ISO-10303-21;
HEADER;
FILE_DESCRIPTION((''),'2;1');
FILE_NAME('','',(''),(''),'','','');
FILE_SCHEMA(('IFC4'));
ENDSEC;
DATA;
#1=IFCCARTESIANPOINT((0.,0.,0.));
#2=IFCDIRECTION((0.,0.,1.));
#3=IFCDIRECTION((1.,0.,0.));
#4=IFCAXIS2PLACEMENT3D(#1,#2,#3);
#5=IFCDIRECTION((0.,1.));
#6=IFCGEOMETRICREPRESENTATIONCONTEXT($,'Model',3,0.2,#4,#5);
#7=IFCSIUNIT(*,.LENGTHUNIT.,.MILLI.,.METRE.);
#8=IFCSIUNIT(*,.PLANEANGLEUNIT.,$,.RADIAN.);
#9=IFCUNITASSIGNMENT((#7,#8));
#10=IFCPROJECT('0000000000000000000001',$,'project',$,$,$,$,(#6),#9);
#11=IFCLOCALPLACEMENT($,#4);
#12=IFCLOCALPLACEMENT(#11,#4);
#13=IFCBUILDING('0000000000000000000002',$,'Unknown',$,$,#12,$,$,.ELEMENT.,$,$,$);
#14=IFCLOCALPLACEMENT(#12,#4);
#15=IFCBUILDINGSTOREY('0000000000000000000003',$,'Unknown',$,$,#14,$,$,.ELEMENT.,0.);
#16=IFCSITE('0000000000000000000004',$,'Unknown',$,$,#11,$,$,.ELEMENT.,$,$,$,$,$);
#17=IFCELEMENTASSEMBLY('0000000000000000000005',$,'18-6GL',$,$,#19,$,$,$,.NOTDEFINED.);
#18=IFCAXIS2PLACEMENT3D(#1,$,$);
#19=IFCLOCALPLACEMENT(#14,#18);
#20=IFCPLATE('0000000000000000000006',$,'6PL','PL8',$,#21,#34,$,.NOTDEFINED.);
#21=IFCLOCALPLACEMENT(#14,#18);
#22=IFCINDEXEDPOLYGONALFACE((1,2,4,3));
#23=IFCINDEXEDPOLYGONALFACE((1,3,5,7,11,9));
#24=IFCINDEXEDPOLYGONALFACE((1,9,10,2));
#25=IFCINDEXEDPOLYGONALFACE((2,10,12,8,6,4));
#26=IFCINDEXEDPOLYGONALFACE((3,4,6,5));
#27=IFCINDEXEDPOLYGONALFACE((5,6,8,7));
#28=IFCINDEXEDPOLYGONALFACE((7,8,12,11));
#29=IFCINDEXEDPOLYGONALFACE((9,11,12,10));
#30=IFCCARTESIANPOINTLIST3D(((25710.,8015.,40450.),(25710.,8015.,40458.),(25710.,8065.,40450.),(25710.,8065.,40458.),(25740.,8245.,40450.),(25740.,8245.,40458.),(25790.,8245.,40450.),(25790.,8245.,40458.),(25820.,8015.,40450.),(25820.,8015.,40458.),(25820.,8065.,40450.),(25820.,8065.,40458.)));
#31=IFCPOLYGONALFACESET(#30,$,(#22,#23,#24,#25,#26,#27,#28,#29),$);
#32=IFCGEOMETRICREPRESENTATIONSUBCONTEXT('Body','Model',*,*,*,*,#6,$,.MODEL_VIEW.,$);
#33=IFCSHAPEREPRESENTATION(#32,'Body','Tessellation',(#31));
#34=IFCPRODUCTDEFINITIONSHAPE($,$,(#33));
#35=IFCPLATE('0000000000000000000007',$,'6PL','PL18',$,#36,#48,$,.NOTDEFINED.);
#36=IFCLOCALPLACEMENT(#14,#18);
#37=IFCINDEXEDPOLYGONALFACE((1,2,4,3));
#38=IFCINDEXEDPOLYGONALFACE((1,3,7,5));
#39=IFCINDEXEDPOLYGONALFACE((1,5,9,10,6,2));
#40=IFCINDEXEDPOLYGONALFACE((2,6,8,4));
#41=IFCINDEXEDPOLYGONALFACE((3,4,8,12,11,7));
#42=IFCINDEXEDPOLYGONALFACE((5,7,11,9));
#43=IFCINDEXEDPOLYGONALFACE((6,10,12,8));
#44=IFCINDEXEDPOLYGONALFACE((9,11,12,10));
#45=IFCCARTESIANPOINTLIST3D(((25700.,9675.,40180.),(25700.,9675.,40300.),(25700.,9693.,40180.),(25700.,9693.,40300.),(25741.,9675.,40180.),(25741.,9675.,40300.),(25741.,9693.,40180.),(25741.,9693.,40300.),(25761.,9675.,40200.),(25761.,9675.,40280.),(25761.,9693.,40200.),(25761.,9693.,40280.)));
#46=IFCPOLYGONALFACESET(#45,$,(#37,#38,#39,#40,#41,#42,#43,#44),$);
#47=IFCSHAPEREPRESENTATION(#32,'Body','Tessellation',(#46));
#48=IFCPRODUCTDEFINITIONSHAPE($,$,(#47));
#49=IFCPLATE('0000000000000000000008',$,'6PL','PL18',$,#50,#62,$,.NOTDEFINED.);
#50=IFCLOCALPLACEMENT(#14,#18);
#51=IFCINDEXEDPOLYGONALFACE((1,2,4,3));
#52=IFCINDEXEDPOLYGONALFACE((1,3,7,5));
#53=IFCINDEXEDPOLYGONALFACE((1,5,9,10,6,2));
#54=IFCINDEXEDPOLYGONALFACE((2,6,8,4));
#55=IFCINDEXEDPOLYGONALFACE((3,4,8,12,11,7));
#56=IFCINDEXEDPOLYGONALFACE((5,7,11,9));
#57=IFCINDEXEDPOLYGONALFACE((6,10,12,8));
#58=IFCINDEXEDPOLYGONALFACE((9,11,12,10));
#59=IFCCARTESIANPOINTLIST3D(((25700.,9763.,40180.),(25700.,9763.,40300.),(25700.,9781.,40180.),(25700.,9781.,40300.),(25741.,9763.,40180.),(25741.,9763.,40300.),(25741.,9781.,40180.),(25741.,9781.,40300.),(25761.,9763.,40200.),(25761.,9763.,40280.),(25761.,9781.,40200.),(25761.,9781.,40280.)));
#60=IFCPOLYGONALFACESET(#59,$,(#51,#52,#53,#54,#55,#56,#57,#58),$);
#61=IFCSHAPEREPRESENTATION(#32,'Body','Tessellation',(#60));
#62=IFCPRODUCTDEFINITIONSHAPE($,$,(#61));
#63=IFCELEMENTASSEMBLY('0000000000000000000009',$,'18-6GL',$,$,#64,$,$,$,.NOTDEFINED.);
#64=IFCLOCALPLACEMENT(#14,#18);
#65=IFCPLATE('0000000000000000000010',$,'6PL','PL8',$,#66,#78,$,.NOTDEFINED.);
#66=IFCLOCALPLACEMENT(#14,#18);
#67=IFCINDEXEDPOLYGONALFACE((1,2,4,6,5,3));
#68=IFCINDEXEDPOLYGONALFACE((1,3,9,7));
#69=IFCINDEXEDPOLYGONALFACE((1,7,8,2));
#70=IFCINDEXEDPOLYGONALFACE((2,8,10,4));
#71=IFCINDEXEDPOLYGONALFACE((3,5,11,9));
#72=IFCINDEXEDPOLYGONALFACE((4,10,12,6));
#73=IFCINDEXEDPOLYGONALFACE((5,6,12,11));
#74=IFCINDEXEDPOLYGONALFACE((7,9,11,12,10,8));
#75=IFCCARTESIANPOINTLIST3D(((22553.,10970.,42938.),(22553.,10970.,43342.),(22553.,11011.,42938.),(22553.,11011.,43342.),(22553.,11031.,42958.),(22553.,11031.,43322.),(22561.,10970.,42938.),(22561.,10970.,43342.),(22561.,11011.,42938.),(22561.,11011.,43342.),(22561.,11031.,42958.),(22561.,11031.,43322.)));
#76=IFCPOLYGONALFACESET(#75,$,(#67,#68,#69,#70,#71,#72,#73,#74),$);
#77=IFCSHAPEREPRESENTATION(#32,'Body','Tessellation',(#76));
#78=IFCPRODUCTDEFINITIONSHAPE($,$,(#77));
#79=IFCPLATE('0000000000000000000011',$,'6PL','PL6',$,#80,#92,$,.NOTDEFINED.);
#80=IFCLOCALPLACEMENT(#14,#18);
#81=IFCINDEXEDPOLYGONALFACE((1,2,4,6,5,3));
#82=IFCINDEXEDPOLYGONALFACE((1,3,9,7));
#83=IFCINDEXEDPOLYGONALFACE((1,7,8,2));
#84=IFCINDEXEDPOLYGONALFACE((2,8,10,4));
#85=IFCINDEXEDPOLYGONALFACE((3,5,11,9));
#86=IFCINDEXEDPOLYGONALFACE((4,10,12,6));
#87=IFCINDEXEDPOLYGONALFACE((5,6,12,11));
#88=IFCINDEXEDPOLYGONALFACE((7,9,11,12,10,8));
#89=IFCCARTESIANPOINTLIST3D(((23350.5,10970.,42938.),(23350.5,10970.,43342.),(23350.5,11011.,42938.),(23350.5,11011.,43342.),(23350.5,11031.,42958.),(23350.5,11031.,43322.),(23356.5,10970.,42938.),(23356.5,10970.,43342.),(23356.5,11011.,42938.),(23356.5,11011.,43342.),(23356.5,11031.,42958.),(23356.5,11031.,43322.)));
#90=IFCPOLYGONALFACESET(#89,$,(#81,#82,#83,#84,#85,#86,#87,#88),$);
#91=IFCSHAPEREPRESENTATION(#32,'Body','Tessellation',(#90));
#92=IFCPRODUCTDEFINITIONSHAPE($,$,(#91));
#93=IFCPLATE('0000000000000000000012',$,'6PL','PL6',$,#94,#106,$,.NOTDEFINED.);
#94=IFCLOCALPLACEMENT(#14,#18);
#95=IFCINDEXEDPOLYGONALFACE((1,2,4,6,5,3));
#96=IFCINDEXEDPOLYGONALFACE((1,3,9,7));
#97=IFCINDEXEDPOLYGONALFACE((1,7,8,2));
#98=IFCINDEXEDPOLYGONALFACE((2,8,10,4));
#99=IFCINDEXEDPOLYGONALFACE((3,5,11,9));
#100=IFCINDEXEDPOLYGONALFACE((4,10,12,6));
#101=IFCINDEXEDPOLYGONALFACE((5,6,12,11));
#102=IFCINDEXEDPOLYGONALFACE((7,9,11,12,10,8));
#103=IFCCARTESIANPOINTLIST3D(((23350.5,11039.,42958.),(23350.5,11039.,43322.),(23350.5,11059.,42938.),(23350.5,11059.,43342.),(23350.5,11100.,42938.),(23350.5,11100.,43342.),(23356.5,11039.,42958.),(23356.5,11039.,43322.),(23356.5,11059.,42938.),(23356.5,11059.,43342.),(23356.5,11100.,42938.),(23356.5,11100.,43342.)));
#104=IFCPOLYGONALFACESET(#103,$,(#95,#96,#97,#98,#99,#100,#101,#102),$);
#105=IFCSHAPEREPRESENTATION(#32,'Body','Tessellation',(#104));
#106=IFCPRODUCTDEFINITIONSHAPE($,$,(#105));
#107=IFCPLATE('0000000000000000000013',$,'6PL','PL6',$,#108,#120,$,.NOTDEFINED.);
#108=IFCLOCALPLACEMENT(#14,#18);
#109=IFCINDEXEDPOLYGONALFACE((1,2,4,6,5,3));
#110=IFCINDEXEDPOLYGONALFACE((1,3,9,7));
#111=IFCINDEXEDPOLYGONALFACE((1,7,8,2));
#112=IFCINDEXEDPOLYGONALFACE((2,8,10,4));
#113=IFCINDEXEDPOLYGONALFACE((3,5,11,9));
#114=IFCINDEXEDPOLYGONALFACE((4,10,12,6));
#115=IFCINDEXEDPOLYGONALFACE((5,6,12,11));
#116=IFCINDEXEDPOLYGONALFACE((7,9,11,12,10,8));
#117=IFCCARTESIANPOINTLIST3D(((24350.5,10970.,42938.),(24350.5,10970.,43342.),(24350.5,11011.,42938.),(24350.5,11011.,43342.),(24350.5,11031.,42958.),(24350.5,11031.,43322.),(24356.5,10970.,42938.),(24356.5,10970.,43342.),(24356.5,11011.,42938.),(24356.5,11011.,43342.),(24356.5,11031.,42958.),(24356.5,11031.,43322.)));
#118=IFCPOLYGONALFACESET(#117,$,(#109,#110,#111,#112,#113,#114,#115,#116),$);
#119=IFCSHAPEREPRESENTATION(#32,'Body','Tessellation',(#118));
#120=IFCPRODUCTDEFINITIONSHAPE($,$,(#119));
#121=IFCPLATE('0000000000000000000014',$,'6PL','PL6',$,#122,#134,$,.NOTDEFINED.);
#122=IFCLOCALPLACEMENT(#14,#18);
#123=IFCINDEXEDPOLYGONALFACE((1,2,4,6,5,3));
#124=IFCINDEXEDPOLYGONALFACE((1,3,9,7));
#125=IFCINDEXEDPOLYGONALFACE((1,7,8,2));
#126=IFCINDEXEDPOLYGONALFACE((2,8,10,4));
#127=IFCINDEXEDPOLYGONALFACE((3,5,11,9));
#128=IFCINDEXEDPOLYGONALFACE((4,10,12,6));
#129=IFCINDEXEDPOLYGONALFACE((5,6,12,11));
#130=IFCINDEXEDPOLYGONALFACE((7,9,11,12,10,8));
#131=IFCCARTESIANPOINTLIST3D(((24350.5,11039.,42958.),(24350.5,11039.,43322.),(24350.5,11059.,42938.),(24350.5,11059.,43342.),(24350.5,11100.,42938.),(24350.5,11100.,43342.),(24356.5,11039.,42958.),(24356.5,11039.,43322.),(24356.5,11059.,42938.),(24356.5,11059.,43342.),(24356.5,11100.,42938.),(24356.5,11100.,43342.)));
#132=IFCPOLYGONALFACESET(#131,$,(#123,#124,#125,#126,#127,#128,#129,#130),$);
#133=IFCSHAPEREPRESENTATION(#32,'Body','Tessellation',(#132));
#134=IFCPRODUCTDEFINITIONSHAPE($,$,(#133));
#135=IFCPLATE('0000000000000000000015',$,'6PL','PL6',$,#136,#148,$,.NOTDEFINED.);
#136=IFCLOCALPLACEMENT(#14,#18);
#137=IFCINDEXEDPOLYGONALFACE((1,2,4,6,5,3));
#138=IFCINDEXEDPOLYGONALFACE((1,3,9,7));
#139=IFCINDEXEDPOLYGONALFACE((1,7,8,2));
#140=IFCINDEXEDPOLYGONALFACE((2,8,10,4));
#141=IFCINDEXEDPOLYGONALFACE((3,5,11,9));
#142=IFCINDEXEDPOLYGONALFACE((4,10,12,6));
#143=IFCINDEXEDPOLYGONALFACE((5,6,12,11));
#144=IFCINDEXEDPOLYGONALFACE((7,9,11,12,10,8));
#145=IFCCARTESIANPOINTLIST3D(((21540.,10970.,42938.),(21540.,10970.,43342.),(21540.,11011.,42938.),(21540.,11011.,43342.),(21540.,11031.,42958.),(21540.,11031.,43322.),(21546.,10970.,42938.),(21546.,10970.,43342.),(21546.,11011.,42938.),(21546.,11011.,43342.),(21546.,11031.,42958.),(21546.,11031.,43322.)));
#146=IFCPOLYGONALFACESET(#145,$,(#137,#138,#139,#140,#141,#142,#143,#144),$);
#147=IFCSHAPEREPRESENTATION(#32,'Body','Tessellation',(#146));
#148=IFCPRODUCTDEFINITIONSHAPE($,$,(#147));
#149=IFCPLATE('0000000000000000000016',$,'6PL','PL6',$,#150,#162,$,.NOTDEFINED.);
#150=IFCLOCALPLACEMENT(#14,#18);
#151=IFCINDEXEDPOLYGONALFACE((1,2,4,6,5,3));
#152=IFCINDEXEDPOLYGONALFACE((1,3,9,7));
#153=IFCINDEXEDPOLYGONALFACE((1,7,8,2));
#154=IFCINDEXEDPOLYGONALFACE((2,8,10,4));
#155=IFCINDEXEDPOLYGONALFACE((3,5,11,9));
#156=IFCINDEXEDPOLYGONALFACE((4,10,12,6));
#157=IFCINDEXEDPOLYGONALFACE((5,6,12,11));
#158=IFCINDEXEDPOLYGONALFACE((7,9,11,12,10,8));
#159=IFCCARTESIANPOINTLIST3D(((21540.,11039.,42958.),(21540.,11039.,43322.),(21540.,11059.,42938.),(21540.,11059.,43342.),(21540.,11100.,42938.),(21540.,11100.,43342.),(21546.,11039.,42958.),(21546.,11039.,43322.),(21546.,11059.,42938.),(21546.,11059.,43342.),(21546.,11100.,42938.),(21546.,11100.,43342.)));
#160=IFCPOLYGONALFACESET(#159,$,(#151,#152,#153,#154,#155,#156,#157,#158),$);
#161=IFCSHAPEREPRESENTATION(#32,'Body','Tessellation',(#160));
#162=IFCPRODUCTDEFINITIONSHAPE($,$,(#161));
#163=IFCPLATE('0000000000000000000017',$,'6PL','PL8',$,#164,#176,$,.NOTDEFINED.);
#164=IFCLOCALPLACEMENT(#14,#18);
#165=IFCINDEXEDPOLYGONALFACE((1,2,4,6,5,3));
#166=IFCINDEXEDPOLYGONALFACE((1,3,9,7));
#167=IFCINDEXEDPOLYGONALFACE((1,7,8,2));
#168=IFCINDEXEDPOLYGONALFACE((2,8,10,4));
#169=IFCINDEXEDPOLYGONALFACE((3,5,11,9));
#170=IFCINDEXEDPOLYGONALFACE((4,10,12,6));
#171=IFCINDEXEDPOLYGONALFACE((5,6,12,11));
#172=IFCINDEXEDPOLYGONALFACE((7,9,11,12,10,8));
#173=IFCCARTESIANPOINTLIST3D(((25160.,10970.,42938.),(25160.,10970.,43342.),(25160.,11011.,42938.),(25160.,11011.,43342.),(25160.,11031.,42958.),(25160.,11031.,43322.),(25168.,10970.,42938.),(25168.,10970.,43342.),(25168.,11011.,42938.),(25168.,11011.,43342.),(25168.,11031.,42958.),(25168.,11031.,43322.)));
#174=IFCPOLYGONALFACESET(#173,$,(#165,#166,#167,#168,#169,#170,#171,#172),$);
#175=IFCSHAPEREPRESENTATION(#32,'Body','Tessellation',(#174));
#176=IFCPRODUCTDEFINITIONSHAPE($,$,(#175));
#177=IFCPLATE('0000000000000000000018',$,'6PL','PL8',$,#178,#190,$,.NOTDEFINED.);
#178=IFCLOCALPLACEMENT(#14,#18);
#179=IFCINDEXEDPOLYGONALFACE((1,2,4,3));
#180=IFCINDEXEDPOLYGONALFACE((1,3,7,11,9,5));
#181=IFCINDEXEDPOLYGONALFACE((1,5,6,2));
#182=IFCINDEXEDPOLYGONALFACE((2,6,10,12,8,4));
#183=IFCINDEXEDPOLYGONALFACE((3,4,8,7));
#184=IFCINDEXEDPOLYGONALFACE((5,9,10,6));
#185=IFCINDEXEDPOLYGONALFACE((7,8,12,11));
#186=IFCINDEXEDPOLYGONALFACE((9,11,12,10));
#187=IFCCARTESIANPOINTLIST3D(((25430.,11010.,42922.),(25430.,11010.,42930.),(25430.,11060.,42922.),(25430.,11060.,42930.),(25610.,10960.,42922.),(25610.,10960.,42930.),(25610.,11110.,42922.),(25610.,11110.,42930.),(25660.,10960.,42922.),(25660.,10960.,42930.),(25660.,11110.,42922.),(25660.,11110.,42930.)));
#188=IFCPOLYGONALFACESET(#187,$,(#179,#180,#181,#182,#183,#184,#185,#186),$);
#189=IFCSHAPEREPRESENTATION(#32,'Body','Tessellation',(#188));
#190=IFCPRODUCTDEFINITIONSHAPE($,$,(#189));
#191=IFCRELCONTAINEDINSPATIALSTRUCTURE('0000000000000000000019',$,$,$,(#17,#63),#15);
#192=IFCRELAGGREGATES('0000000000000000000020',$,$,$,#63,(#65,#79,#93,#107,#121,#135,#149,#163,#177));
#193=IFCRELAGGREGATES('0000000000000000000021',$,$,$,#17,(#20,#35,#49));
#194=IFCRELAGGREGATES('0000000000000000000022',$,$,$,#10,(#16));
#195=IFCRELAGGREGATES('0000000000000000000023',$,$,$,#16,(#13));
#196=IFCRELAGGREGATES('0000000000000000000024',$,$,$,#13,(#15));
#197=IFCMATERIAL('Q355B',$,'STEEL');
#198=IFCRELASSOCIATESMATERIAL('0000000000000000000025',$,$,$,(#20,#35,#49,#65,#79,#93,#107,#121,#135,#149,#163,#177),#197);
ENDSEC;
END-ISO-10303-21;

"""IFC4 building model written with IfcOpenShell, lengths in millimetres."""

from ifc_helpers import new_model, si_unit, direction, frame, origin_with_axes, place, context, subcontext, project, spatial, line, indexed_curve, outline, extrude, material, element, aggregate, save


model = new_model("IFC4")

# Units and contexts
model_context = context("Model", 3, precision=0.2, world=origin_with_axes(), true_north=direction((0.0, 1.0)))
body_context = subcontext(model_context, "Body", "Model", "MODEL_VIEW")
ifc_project = project(units=[si_unit("LENGTHUNIT", "METRE", prefix="MILLI"), si_unit("PLANEANGLEUNIT", "RADIAN")], contexts=[model_context])

# Site, building, storey
site_placement = place(None, origin_with_axes())
site = spatial("IfcSite", under=ifc_project, at=site_placement, Name="Unknown", CompositionType="ELEMENT")
building_placement = place(site_placement, origin_with_axes())
building = spatial("IfcBuilding", under=site, at=building_placement, Name="Unknown", CompositionType="ELEMENT")
storey_placement = place(building_placement, origin_with_axes())
storey = spatial("IfcBuildingStorey", under=building, at=storey_placement, Name="Unknown", CompositionType="ELEMENT", Elevation=0.0)

# Element assembly
assembly_1_placement = place(storey_placement, frame((25765.0, 10900.0, 40240.0), z_axis=(-1.0, 0.0, 0.0), x_axis=(0.0, -1.0, 0.0)))
assembly_1 = element("IfcElementAssembly", 1, at=assembly_1_placement, inside=storey, Name="18-6GL", PredefinedType="NOTDEFINED")
ifc_material_1 = material(Name="Q355B", Category="STEEL")

# Plates
plate_1_placement = place(assembly_1_placement, frame((2835.0, 214.0, -55.0), z_axis=(0.0, -1.0, 0.0), x_axis=(1.0, 0.0, 0.0)))
plate_1 = element("IfcPlate", 2, at=plate_1_placement, material=ifc_material_1, Name="6PL", Description="PL8", PredefinedType="NOTDEFINED", context=body_context, shape_type="SolidModel", body=[
    extrude(outline(indexed_curve([(0.0, 0.0), (50.0, 0.0), (50.0, 110.0), (0.0, 110.0), (-180.0, 80.0), (-180.0, 30.0)], segments=[line(1, 2, 3, 4, 5, 6, 1)])), frame((0.0, 0.0, 4.0), z_axis=(0.0, 0.0, 1.0), x_axis=(1.0, 0.0, 0.0)), (0.0, 0.0, -1.0), 8.0),
])
plate_2_placement = place(assembly_1_placement, frame((1216.0, -60.0, 65.0), z_axis=(1.0, 0.0, 0.0), x_axis=(0.0, 0.0, -1.0)))
plate_2 = element("IfcPlate", 3, at=plate_2_placement, material=ifc_material_1, Name="6PL", Description="PL18", PredefinedType="NOTDEFINED", context=body_context, shape_type="SolidModel", body=[
    extrude(outline(indexed_curve([(0.0, 0.0), (41.0, 0.0), (61.0, 20.0), (61.0, 100.0), (41.0, 120.0), (0.0, 120.0)], segments=[line(1, 2, 3, 4, 5, 6, 1)])), frame((0.0, 0.0, 9.0), z_axis=(0.0, 0.0, 1.0), x_axis=(1.0, 0.0, 0.0)), (0.0, 0.0, -1.0), 18.0),
])
plate_3_placement = place(assembly_1_placement, frame((1128.0, -60.0, 65.0), z_axis=(1.0, 0.0, 0.0), x_axis=(0.0, 0.0, -1.0)))
plate_3 = element("IfcPlate", 4, at=plate_3_placement, material=ifc_material_1, Name="6PL", Description="PL18", PredefinedType="NOTDEFINED", context=body_context, shape_type="SolidModel", body=[
    extrude(outline(indexed_curve([(0.0, 0.0), (41.0, 0.0), (61.0, 20.0), (61.0, 100.0), (41.0, 120.0), (0.0, 120.0)], segments=[line(1, 2, 3, 4, 5, 6, 1)])), frame((0.0, 0.0, 9.0), z_axis=(0.0, 0.0, 1.0), x_axis=(1.0, 0.0, 0.0)), (0.0, 0.0, -1.0), 18.0),
])

# Element assembly, plates
assembly_2_placement = place(storey_placement, frame((21150.0, 11035.0, 43140.0), z_axis=(0.0, -1.0, 0.0), x_axis=(1.0, 0.0, 0.0)))
assembly_2 = element("IfcElementAssembly", 5, at=assembly_2_placement, inside=storey, Name="18-6GL", PredefinedType="NOTDEFINED")
plate_4_placement = place(assembly_2_placement, frame((1407.0, -202.0, 4.0), z_axis=(-1.0, 0.0, 0.0), x_axis=(0.0, 0.0, 1.0)))
plate_4 = element("IfcPlate", 6, at=plate_4_placement, material=ifc_material_1, Name="6PL", Description="PL8", PredefinedType="NOTDEFINED", context=body_context, shape_type="SolidModel", body=[
    extrude(outline(indexed_curve([(0.0, 20.0), (20.0, 0.0), (61.0, 0.0), (61.0, 404.0), (20.0, 404.0), (0.0, 384.0)], segments=[line(1, 2, 3, 4, 5, 6, 1)])), frame((0.0, 0.0, 4.0), z_axis=(0.0, 0.0, 1.0), x_axis=(1.0, 0.0, 0.0)), (0.0, 0.0, -1.0), 8.0),
])
plate_5_placement = place(assembly_2_placement, frame((2203.5, -202.0, 65.0), z_axis=(1.0, 0.0, 0.0), x_axis=(0.0, 0.0, -1.0)))
plate_5 = element("IfcPlate", 7, at=plate_5_placement, material=ifc_material_1, Name="6PL", Description="PL6", PredefinedType="NOTDEFINED", context=body_context, shape_type="SolidModel", body=[
    extrude(outline(indexed_curve([(0.0, 0.0), (41.0, 0.0), (61.0, 20.0), (61.0, 384.0), (41.0, 404.0), (0.0, 404.0)], segments=[line(1, 2, 3, 4, 5, 6, 1)])), frame((0.0, 0.0, 3.0), z_axis=(0.0, 0.0, 1.0), x_axis=(1.0, 0.0, 0.0)), (0.0, 0.0, -1.0), 6.0),
])
plate_6_placement = place(assembly_2_placement, frame((2203.5, -202.0, -4.0), z_axis=(1.0, 0.0, 0.0), x_axis=(0.0, 0.0, -1.0)))
plate_6 = element("IfcPlate", 8, at=plate_6_placement, material=ifc_material_1, Name="6PL", Description="PL6", PredefinedType="NOTDEFINED", context=body_context, shape_type="SolidModel", body=[
    extrude(outline(indexed_curve([(0.0, 20.0), (20.0, 0.0), (61.0, 0.0), (61.0, 404.0), (20.0, 404.0), (0.0, 384.0)], segments=[line(1, 2, 3, 4, 5, 6, 1)])), frame((0.0, 0.0, 3.0), z_axis=(0.0, 0.0, 1.0), x_axis=(1.0, 0.0, 0.0)), (0.0, 0.0, -1.0), 6.0),
])
plate_7_placement = place(assembly_2_placement, frame((3203.5, -202.0, 65.0), z_axis=(1.0, 0.0, 0.0), x_axis=(0.0, 0.0, -1.0)))
plate_7 = element("IfcPlate", 9, at=plate_7_placement, material=ifc_material_1, Name="6PL", Description="PL6", PredefinedType="NOTDEFINED", context=body_context, shape_type="SolidModel", body=[
    extrude(outline(indexed_curve([(0.0, 0.0), (41.0, 0.0), (61.0, 20.0), (61.0, 384.0), (41.0, 404.0), (0.0, 404.0)], segments=[line(1, 2, 3, 4, 5, 6, 1)])), frame((0.0, 0.0, 3.0), z_axis=(0.0, 0.0, 1.0), x_axis=(1.0, 0.0, 0.0)), (0.0, 0.0, -1.0), 6.0),
])
plate_8_placement = place(assembly_2_placement, frame((3203.5, -202.0, -4.0), z_axis=(1.0, 0.0, 0.0), x_axis=(0.0, 0.0, -1.0)))
plate_8 = element("IfcPlate", 10, at=plate_8_placement, material=ifc_material_1, Name="6PL", Description="PL6", PredefinedType="NOTDEFINED", context=body_context, shape_type="SolidModel", body=[
    extrude(outline(indexed_curve([(0.0, 20.0), (20.0, 0.0), (61.0, 0.0), (61.0, 404.0), (20.0, 404.0), (0.0, 384.0)], segments=[line(1, 2, 3, 4, 5, 6, 1)])), frame((0.0, 0.0, 3.0), z_axis=(0.0, 0.0, 1.0), x_axis=(1.0, 0.0, 0.0)), (0.0, 0.0, -1.0), 6.0),
])
plate_9_placement = place(assembly_2_placement, frame((393.0, -202.0, 65.0), z_axis=(1.0, 0.0, 0.0), x_axis=(0.0, 0.0, -1.0)))
plate_9 = element("IfcPlate", 11, at=plate_9_placement, material=ifc_material_1, Name="6PL", Description="PL6", PredefinedType="NOTDEFINED", context=body_context, shape_type="SolidModel", body=[
    extrude(outline(indexed_curve([(0.0, 0.0), (41.0, 0.0), (61.0, 20.0), (61.0, 384.0), (41.0, 404.0), (0.0, 404.0)], segments=[line(1, 2, 3, 4, 5, 6, 1)])), frame((0.0, 0.0, 3.0), z_axis=(0.0, 0.0, 1.0), x_axis=(1.0, 0.0, 0.0)), (0.0, 0.0, -1.0), 6.0),
])
plate_10_placement = place(assembly_2_placement, frame((393.0, -202.0, -4.0), z_axis=(1.0, 0.0, 0.0), x_axis=(0.0, 0.0, -1.0)))
plate_10 = element("IfcPlate", 12, at=plate_10_placement, material=ifc_material_1, Name="6PL", Description="PL6", PredefinedType="NOTDEFINED", context=body_context, shape_type="SolidModel", body=[
    extrude(outline(indexed_curve([(0.0, 20.0), (20.0, 0.0), (61.0, 0.0), (61.0, 404.0), (20.0, 404.0), (0.0, 384.0)], segments=[line(1, 2, 3, 4, 5, 6, 1)])), frame((0.0, 0.0, 3.0), z_axis=(0.0, 0.0, 1.0), x_axis=(1.0, 0.0, 0.0)), (0.0, 0.0, -1.0), 6.0),
])
plate_11_placement = place(assembly_2_placement, frame((4014.0, -202.0, 65.0), z_axis=(1.0, 0.0, 0.0), x_axis=(0.0, 0.0, -1.0)))
plate_11 = element("IfcPlate", 13, at=plate_11_placement, material=ifc_material_1, Name="6PL", Description="PL8", PredefinedType="NOTDEFINED", context=body_context, shape_type="SolidModel", body=[
    extrude(outline(indexed_curve([(0.0, 0.0), (41.0, 0.0), (61.0, 20.0), (61.0, 384.0), (41.0, 404.0), (0.0, 404.0)], segments=[line(1, 2, 3, 4, 5, 6, 1)])), frame((0.0, 0.0, 4.0), z_axis=(0.0, 0.0, 1.0), x_axis=(1.0, 0.0, 0.0)), (0.0, 0.0, -1.0), 8.0),
])
plate_12_placement = place(assembly_2_placement, frame((4460.0, -214.0, 75.0), z_axis=(0.0, 1.0, 0.0), x_axis=(1.0, 0.0, 0.0)))
plate_12 = element("IfcPlate", 14, at=plate_12_placement, material=ifc_material_1, Name="6PL", Description="PL8", PredefinedType="NOTDEFINED", context=body_context, shape_type="SolidModel", body=[
    extrude(outline(indexed_curve([(0.0, 0.0), (50.0, 0.0), (50.0, 150.0), (0.0, 150.0), (-180.0, 100.0), (-180.0, 50.0)], segments=[line(1, 2, 3, 4, 5, 6, 1)])), frame((0.0, 0.0, 4.0), z_axis=(0.0, 0.0, 1.0), x_axis=(1.0, 0.0, 0.0)), (0.0, 0.0, -1.0), 8.0),
])
aggregate(assembly_2, [plate_4, plate_5, plate_6, plate_7, plate_8, plate_9, plate_10, plate_11, plate_12])

aggregate(assembly_1, [plate_1, plate_2, plate_3])

save(model, "model.ifc")
